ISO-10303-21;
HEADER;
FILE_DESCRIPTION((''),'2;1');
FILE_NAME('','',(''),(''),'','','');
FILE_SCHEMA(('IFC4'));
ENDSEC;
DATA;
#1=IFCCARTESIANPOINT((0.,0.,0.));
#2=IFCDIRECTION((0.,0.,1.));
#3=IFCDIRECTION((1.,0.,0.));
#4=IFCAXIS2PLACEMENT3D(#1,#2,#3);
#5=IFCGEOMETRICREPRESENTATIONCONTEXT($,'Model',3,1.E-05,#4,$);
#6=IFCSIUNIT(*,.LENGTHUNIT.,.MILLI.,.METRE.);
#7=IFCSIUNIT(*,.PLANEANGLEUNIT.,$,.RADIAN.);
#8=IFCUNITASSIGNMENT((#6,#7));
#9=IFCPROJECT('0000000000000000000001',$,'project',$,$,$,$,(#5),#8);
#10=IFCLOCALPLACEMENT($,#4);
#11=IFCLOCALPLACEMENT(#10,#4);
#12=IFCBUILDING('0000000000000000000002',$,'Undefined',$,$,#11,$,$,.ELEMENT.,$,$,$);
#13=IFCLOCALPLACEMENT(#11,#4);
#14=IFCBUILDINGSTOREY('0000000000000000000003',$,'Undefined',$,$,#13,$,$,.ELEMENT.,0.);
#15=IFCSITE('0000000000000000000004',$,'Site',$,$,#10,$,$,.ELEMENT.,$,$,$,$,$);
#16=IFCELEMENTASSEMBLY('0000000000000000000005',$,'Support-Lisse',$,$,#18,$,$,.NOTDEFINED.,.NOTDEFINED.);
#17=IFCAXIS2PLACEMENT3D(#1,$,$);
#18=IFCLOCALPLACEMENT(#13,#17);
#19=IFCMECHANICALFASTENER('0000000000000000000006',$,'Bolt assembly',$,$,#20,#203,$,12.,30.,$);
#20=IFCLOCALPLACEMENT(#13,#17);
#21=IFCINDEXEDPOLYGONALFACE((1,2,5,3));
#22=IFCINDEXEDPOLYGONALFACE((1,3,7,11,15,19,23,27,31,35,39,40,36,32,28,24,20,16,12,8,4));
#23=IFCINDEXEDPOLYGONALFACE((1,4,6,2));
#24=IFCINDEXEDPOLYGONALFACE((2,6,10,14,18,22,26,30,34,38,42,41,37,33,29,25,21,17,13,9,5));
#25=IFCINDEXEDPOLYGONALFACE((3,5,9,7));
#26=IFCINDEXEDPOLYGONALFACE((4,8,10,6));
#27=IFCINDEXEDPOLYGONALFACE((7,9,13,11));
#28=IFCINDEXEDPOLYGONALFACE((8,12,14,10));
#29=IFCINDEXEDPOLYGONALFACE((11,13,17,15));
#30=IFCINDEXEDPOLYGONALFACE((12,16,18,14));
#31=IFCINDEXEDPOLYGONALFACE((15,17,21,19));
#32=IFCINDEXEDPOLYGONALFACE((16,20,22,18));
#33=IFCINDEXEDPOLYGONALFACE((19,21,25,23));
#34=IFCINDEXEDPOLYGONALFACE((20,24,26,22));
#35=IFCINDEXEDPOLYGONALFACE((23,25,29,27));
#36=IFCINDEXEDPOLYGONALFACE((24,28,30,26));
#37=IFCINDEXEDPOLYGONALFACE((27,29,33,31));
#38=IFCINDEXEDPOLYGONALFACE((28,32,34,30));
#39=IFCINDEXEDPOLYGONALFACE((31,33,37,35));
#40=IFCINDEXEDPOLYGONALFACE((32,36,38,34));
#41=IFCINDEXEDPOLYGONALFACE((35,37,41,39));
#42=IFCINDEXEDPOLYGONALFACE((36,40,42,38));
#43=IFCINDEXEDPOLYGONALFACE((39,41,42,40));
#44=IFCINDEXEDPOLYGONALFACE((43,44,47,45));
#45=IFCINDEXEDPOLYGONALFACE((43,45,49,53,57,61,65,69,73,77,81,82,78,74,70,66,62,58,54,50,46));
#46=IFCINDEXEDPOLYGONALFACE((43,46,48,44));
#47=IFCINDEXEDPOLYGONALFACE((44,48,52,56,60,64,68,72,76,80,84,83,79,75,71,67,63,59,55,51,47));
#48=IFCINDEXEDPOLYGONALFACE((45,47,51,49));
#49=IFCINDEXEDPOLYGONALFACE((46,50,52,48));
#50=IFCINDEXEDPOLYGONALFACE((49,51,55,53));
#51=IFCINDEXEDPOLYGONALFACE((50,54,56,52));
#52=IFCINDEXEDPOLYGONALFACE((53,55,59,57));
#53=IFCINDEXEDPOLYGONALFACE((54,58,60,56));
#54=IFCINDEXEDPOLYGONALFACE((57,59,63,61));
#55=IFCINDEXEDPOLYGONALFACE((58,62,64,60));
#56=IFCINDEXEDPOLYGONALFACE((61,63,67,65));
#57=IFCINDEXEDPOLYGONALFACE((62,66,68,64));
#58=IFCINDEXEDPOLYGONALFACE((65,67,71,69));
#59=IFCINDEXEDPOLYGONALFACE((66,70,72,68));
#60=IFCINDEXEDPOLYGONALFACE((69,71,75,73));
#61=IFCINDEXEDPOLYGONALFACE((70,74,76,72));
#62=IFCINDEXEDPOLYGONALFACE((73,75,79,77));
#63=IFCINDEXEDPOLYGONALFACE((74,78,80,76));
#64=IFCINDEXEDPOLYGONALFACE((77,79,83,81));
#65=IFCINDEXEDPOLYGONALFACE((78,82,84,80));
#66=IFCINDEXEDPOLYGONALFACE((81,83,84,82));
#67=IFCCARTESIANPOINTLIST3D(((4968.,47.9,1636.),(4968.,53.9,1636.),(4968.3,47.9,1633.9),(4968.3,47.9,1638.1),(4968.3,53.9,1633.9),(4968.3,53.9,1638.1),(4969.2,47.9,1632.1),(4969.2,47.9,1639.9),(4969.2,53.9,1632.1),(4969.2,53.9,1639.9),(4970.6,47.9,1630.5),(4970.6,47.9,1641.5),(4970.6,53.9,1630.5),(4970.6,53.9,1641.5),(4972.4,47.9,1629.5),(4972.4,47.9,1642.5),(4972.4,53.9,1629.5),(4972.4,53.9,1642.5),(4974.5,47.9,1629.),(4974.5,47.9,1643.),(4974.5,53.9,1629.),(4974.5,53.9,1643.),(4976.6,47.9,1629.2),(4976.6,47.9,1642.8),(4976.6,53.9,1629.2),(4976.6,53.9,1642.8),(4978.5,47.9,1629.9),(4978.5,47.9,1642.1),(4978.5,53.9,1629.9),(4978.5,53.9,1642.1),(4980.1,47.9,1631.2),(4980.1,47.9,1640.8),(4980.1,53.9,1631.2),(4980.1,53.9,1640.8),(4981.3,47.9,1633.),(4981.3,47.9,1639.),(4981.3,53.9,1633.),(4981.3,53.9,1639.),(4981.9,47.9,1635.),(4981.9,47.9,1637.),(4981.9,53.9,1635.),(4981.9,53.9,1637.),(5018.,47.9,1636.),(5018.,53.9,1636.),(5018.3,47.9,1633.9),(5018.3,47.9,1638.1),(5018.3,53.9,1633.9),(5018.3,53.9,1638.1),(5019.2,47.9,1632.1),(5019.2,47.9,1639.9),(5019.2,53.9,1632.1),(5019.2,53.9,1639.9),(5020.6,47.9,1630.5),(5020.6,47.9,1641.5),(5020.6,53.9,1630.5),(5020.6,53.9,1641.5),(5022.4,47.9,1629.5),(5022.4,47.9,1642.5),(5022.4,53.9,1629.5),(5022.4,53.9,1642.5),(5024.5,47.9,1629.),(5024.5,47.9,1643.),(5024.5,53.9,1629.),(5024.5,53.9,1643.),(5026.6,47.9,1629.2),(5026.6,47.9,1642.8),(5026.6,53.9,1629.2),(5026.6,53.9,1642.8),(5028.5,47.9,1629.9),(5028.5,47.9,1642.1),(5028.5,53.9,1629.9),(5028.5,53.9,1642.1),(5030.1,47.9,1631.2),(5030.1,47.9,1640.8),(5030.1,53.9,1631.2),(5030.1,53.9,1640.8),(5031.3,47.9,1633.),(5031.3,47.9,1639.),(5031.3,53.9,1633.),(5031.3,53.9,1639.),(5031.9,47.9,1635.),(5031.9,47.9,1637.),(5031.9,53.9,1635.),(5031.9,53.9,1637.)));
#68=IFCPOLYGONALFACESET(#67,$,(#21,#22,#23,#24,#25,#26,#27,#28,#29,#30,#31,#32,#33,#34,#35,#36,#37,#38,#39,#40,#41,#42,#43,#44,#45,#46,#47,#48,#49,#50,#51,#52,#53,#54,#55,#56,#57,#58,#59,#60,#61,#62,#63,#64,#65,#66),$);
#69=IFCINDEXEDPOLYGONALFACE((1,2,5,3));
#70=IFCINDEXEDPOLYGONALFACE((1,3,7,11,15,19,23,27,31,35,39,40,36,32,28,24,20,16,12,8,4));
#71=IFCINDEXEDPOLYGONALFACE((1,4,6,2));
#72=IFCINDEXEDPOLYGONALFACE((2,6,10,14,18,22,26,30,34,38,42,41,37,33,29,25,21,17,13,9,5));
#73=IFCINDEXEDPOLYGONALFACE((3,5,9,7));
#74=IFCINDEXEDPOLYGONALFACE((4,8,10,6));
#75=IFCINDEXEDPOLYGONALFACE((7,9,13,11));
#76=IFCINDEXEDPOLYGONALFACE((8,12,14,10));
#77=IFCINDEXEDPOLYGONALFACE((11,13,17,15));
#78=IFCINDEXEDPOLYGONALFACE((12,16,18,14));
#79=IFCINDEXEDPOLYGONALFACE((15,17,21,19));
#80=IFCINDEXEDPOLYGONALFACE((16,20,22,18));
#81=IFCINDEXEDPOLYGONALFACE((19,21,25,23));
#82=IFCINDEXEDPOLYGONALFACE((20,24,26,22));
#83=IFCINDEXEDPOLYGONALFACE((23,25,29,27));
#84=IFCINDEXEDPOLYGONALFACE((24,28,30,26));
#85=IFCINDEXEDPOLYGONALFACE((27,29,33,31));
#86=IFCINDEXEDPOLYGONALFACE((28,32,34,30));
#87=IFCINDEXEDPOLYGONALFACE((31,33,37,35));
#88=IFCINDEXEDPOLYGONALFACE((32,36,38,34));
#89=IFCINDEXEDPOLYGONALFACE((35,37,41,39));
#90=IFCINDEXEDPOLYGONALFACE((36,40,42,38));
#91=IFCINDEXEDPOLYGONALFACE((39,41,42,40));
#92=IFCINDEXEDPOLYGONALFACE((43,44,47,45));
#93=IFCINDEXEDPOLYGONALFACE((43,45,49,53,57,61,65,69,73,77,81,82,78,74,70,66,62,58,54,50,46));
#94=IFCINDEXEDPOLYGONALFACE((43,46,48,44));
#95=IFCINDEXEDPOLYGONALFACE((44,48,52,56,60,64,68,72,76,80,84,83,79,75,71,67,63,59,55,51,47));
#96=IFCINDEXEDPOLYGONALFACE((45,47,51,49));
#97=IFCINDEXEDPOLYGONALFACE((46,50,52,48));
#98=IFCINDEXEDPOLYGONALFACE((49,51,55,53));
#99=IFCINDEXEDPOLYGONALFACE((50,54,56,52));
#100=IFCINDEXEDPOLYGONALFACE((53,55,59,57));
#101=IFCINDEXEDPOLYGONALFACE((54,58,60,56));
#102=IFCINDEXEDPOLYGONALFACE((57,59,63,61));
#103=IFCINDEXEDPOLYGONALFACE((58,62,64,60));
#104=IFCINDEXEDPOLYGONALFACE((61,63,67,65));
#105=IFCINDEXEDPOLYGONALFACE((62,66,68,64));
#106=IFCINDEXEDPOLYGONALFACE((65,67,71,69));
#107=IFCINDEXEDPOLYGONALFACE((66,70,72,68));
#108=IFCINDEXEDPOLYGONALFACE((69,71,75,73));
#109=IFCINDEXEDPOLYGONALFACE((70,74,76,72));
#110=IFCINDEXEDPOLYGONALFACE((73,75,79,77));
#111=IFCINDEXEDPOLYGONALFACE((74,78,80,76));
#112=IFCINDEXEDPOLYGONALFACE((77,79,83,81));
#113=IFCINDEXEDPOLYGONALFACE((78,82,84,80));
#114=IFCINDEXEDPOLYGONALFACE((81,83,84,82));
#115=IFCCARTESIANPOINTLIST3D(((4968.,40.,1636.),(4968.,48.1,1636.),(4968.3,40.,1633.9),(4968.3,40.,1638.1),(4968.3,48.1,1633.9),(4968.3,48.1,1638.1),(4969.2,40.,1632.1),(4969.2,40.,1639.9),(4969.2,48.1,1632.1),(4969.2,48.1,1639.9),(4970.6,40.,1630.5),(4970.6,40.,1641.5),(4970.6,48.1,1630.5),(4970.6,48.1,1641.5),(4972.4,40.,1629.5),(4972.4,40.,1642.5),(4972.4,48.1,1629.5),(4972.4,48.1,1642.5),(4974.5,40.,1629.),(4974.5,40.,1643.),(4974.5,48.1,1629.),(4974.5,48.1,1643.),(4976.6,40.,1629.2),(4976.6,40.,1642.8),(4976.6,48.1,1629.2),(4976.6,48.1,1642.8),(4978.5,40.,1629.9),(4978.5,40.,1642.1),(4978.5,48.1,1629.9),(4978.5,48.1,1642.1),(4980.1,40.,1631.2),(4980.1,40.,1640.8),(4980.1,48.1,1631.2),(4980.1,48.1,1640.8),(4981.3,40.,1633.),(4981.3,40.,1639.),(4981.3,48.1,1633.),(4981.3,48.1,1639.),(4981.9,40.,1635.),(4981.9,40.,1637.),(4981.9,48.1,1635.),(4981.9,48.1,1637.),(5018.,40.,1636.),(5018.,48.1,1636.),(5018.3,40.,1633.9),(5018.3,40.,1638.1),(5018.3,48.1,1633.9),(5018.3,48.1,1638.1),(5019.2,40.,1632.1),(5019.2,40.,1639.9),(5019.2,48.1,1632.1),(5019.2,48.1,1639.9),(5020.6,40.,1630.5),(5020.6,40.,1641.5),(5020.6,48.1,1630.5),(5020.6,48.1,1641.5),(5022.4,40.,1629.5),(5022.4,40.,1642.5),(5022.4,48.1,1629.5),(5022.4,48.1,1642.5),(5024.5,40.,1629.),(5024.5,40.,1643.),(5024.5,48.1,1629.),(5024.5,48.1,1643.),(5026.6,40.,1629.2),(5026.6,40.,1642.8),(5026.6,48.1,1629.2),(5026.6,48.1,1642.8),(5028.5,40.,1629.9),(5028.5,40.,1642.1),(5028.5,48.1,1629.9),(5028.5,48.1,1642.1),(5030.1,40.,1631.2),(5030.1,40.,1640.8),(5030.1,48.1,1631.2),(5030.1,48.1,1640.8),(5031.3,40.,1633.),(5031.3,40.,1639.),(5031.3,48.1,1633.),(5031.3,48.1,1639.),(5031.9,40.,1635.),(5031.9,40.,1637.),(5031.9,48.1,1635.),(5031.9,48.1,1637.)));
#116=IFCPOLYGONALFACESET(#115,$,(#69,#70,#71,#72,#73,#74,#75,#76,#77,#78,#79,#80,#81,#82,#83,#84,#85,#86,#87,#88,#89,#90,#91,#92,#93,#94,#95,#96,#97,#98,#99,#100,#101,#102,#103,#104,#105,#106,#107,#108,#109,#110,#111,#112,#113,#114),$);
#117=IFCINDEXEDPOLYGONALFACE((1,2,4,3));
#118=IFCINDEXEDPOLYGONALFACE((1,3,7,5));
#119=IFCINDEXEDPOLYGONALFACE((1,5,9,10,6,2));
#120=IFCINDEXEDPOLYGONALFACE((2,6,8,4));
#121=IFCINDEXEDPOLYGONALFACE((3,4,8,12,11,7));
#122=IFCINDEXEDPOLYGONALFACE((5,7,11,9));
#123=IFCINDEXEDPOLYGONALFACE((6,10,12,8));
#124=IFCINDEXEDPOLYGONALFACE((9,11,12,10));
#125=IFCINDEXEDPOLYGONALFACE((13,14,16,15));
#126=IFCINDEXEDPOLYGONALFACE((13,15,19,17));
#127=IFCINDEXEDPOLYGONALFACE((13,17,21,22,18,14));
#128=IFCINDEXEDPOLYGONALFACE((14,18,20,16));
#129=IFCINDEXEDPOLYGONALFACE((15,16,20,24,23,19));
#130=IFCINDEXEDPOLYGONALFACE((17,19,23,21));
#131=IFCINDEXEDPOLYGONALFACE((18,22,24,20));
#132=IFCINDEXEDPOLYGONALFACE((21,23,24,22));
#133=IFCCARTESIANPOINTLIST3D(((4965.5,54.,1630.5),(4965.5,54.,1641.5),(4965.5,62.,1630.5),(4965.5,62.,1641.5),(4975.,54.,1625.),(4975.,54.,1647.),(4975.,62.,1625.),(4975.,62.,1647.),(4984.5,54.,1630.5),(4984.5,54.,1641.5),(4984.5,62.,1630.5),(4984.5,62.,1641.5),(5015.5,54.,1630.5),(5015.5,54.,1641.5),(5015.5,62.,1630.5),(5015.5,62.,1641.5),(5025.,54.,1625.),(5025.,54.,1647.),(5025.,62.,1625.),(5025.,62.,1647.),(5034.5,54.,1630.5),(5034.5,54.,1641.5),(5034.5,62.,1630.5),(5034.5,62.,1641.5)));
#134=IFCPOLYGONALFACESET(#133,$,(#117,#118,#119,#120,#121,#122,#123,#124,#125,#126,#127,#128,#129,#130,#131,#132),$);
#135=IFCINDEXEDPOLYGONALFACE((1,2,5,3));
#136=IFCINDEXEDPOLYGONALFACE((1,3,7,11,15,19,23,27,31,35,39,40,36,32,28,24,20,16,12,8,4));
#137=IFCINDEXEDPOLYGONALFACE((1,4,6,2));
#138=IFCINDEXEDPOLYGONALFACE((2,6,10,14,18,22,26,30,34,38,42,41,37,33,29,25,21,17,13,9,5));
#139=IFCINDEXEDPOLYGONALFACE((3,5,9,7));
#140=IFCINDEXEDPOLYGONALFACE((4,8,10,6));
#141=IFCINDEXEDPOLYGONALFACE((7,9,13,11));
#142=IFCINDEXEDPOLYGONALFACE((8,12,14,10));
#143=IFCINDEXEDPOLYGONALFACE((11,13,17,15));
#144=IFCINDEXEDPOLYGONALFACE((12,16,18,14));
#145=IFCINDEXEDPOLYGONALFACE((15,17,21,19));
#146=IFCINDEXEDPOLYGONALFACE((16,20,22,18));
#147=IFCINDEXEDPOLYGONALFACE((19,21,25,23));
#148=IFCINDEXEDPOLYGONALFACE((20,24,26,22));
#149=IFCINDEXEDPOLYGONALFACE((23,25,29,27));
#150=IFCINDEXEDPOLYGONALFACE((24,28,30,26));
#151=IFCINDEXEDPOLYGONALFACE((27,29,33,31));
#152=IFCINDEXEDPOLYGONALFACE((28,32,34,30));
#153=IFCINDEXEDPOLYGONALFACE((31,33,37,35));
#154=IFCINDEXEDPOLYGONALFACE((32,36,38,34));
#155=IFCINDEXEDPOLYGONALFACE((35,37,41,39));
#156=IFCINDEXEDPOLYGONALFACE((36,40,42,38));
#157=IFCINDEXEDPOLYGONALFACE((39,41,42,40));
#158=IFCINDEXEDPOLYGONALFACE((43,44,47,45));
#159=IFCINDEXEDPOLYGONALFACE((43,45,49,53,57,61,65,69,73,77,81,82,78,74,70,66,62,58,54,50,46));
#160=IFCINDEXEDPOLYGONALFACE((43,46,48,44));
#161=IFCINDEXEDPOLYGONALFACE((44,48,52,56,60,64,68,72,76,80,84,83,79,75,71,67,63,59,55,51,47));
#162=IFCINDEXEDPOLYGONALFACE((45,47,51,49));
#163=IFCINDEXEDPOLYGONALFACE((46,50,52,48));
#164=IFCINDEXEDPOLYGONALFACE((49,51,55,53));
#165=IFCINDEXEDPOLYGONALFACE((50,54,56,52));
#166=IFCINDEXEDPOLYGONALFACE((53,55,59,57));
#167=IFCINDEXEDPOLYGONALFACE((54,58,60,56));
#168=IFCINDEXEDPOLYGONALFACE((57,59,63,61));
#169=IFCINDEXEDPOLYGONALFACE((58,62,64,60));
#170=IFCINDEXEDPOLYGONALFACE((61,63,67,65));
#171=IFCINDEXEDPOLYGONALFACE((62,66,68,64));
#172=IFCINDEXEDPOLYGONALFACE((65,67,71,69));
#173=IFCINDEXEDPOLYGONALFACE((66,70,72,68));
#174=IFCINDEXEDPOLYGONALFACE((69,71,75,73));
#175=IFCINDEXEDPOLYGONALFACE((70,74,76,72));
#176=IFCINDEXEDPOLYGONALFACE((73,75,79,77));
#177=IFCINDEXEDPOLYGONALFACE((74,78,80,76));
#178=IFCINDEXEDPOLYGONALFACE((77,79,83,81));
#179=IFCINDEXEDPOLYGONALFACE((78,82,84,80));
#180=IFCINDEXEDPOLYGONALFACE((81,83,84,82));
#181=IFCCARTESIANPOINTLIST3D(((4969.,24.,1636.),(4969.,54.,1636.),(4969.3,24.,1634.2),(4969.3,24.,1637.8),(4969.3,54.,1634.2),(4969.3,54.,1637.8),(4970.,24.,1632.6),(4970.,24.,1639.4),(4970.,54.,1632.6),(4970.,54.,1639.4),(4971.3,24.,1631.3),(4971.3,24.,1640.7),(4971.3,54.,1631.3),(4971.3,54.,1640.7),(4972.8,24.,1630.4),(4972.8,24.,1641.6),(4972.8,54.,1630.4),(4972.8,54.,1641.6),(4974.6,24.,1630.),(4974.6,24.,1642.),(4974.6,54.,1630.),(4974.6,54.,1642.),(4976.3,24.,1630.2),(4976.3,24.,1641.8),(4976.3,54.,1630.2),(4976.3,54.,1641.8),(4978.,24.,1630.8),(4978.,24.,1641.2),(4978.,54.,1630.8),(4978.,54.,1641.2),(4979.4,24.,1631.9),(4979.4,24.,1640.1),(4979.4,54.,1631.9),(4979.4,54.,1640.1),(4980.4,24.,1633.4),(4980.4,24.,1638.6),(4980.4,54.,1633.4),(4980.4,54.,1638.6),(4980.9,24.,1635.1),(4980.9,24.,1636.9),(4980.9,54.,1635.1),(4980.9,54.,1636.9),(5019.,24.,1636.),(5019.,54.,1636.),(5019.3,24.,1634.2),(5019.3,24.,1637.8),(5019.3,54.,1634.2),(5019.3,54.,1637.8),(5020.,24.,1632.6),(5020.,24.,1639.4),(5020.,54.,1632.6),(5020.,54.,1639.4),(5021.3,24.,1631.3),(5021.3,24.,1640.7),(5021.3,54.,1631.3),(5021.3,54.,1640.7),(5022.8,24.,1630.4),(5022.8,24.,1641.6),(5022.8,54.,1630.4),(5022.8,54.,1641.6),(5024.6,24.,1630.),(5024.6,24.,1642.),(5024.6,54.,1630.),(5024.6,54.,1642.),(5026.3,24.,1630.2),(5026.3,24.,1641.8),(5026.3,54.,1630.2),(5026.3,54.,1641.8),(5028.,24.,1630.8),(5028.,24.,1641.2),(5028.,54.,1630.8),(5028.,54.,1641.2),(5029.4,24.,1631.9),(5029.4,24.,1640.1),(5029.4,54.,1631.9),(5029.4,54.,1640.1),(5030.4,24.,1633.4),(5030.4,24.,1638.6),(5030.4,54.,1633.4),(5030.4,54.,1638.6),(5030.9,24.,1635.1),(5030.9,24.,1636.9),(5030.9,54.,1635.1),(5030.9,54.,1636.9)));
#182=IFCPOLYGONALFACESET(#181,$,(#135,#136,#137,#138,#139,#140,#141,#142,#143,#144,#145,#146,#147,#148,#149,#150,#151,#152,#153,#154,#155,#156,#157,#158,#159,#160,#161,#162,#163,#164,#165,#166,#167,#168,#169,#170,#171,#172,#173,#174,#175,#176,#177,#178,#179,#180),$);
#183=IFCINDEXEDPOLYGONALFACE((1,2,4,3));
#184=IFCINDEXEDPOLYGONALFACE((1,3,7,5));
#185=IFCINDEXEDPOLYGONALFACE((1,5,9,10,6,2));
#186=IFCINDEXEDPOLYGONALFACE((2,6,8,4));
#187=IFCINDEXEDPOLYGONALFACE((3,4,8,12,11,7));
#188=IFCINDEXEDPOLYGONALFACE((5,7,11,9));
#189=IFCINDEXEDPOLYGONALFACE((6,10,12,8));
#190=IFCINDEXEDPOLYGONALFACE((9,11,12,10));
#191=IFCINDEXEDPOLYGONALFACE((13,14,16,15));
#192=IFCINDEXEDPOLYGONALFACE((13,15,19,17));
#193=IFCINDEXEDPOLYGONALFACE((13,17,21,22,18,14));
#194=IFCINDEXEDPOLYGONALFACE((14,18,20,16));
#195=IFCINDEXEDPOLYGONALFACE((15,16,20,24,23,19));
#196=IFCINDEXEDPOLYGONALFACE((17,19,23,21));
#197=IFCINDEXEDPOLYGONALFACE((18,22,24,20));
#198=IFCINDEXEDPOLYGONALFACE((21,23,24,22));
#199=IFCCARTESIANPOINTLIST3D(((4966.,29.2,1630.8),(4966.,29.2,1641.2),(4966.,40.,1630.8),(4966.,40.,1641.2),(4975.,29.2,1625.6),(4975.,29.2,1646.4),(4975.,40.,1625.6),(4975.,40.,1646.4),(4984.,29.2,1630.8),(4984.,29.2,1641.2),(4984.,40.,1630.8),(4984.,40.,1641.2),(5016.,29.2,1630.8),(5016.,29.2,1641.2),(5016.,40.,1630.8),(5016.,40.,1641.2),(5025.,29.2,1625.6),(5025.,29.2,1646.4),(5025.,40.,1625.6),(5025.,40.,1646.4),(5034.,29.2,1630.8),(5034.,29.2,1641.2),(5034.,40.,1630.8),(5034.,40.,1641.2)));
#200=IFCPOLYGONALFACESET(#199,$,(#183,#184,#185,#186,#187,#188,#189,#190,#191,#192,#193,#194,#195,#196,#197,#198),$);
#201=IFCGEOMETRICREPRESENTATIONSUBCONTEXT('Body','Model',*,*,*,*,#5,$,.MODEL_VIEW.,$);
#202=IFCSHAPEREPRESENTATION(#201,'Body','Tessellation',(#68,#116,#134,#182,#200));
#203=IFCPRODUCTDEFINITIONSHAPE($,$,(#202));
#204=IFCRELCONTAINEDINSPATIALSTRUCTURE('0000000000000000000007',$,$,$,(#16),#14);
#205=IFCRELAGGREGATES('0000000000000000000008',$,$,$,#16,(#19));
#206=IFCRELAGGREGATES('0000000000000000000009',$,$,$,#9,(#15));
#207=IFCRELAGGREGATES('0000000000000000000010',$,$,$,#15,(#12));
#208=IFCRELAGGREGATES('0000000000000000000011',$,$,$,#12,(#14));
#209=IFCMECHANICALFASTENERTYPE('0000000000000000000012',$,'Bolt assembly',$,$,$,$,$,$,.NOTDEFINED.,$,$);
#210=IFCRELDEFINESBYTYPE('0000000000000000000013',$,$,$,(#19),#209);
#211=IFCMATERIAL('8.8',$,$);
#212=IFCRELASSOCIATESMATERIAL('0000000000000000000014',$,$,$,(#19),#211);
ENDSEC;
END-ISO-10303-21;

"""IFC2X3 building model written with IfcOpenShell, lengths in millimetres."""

from ifc_helpers import new_model, si_unit, frame, origin_with_axes, origin_2d_with_axis, place, context, subcontext, project, spatial, polyline, circle, outline, extrude, source, transform, mapped, material, type_object, element, aggregate, save


model = new_model("IFC2X3")

# Units and contexts
model_context = context("Model", 3, precision=1e-05, world=origin_with_axes())
body_context = subcontext(model_context, "Body", "Model", "MODEL_VIEW")
ifc_project = project(units=[si_unit("LENGTHUNIT", "METRE", prefix="MILLI"), si_unit("PLANEANGLEUNIT", "RADIAN")], contexts=[model_context])

# Site, building, storey
site_placement = place(None, origin_with_axes())
site = spatial("IfcSite", under=ifc_project, at=site_placement, Name="Site", CompositionType="ELEMENT")
building_placement = place(site_placement, origin_with_axes())
building = spatial("IfcBuilding", under=site, at=building_placement, Name="Undefined", CompositionType="ELEMENT")
storey_placement = place(building_placement, origin_with_axes())
storey = spatial("IfcBuildingStorey", under=building, at=storey_placement, Name="Undefined", CompositionType="ELEMENT", Elevation=0.0)

# Shared definitions
mechanical_fastener_type = type_object("IfcMechanicalFastenerType", Name="Bolt assembly")

# Element assembly, mechanical fastener
ifc_material_1 = material(Name="8.8")
shared_shape_1 = source(origin_with_axes(), body_context, "Body", "SweptSolid", [
    extrude(circle(Radius=7.0, at=origin_2d_with_axis()), frame((0.0, -5.9, 0.0), z_axis=(0.0, 1.0, 0.0), x_axis=(1.0, 0.0, 0.0)), (0.0, 0.0, 1.0), 6.0),
    extrude(circle(Radius=7.0, at=origin_2d_with_axis()), frame((0.0, -0.1, 0.0), z_axis=(0.0, 1.0, 0.0), x_axis=(1.0, 0.0, 0.0)), (0.0, 0.0, 1.0), 8.1),
    extrude(outline(polyline([(9.5, -5.5), (9.5, 5.5), (0.0, 11.0), (-9.5, 5.5), (-9.5, -5.5), (0.0, -11.0), (9.5, -5.5)])), frame((0.0, -14.0, 0.0), z_axis=(0.0, 1.0, 0.0), x_axis=(1.0, 0.0, 0.0)), (0.0, 0.0, 1.0), 8.0),
    extrude(circle(Radius=6.0, at=origin_2d_with_axis()), frame((0.0, -6.0, 0.0), z_axis=(0.0, 1.0, 0.0), x_axis=(1.0, 0.0, 0.0)), (0.0, 0.0, 1.0), 30.0),
    extrude(outline(polyline([(9.0, -5.2), (9.0, 5.2), (0.0, 10.4), (-9.0, 5.2), (-9.0, -5.2), (0.0, -10.4), (9.0, -5.2)])), frame((0.0, 8.0, 0.0), z_axis=(0.0, 1.0, 0.0), x_axis=(1.0, 0.0, 0.0)), (0.0, 0.0, 1.0), 10.8),
])
assembly_1_placement = place(storey_placement, origin_with_axes())
assembly_1 = element("IfcElementAssembly", 1, at=assembly_1_placement, inside=storey, Name="Support-Lisse", AssemblyPlace="NOTDEFINED", PredefinedType="NOTDEFINED")
mechanical_fastener_1_placement = place(assembly_1_placement, frame((5025.0, 48.0, 1636.0), z_axis=(0.0, 0.0, 1.0), x_axis=(-1.0, 0.0, 0.0)))
mechanical_fastener_1 = element("IfcMechanicalFastener", 2, at=mechanical_fastener_1_placement, type_object=mechanical_fastener_type, material=ifc_material_1, Name="Bolt assembly", NominalDiameter=12.0, NominalLength=30.0, context=body_context, shape_type="MappedRepresentation", body=[
    mapped(shared_shape_1, transform((0.0, 0.0, 0.0))),
    mapped(shared_shape_1, transform((50.0, 0.0, 0.0))),
])
aggregate(assembly_1, [mechanical_fastener_1])

save(model, "model.ifc")
